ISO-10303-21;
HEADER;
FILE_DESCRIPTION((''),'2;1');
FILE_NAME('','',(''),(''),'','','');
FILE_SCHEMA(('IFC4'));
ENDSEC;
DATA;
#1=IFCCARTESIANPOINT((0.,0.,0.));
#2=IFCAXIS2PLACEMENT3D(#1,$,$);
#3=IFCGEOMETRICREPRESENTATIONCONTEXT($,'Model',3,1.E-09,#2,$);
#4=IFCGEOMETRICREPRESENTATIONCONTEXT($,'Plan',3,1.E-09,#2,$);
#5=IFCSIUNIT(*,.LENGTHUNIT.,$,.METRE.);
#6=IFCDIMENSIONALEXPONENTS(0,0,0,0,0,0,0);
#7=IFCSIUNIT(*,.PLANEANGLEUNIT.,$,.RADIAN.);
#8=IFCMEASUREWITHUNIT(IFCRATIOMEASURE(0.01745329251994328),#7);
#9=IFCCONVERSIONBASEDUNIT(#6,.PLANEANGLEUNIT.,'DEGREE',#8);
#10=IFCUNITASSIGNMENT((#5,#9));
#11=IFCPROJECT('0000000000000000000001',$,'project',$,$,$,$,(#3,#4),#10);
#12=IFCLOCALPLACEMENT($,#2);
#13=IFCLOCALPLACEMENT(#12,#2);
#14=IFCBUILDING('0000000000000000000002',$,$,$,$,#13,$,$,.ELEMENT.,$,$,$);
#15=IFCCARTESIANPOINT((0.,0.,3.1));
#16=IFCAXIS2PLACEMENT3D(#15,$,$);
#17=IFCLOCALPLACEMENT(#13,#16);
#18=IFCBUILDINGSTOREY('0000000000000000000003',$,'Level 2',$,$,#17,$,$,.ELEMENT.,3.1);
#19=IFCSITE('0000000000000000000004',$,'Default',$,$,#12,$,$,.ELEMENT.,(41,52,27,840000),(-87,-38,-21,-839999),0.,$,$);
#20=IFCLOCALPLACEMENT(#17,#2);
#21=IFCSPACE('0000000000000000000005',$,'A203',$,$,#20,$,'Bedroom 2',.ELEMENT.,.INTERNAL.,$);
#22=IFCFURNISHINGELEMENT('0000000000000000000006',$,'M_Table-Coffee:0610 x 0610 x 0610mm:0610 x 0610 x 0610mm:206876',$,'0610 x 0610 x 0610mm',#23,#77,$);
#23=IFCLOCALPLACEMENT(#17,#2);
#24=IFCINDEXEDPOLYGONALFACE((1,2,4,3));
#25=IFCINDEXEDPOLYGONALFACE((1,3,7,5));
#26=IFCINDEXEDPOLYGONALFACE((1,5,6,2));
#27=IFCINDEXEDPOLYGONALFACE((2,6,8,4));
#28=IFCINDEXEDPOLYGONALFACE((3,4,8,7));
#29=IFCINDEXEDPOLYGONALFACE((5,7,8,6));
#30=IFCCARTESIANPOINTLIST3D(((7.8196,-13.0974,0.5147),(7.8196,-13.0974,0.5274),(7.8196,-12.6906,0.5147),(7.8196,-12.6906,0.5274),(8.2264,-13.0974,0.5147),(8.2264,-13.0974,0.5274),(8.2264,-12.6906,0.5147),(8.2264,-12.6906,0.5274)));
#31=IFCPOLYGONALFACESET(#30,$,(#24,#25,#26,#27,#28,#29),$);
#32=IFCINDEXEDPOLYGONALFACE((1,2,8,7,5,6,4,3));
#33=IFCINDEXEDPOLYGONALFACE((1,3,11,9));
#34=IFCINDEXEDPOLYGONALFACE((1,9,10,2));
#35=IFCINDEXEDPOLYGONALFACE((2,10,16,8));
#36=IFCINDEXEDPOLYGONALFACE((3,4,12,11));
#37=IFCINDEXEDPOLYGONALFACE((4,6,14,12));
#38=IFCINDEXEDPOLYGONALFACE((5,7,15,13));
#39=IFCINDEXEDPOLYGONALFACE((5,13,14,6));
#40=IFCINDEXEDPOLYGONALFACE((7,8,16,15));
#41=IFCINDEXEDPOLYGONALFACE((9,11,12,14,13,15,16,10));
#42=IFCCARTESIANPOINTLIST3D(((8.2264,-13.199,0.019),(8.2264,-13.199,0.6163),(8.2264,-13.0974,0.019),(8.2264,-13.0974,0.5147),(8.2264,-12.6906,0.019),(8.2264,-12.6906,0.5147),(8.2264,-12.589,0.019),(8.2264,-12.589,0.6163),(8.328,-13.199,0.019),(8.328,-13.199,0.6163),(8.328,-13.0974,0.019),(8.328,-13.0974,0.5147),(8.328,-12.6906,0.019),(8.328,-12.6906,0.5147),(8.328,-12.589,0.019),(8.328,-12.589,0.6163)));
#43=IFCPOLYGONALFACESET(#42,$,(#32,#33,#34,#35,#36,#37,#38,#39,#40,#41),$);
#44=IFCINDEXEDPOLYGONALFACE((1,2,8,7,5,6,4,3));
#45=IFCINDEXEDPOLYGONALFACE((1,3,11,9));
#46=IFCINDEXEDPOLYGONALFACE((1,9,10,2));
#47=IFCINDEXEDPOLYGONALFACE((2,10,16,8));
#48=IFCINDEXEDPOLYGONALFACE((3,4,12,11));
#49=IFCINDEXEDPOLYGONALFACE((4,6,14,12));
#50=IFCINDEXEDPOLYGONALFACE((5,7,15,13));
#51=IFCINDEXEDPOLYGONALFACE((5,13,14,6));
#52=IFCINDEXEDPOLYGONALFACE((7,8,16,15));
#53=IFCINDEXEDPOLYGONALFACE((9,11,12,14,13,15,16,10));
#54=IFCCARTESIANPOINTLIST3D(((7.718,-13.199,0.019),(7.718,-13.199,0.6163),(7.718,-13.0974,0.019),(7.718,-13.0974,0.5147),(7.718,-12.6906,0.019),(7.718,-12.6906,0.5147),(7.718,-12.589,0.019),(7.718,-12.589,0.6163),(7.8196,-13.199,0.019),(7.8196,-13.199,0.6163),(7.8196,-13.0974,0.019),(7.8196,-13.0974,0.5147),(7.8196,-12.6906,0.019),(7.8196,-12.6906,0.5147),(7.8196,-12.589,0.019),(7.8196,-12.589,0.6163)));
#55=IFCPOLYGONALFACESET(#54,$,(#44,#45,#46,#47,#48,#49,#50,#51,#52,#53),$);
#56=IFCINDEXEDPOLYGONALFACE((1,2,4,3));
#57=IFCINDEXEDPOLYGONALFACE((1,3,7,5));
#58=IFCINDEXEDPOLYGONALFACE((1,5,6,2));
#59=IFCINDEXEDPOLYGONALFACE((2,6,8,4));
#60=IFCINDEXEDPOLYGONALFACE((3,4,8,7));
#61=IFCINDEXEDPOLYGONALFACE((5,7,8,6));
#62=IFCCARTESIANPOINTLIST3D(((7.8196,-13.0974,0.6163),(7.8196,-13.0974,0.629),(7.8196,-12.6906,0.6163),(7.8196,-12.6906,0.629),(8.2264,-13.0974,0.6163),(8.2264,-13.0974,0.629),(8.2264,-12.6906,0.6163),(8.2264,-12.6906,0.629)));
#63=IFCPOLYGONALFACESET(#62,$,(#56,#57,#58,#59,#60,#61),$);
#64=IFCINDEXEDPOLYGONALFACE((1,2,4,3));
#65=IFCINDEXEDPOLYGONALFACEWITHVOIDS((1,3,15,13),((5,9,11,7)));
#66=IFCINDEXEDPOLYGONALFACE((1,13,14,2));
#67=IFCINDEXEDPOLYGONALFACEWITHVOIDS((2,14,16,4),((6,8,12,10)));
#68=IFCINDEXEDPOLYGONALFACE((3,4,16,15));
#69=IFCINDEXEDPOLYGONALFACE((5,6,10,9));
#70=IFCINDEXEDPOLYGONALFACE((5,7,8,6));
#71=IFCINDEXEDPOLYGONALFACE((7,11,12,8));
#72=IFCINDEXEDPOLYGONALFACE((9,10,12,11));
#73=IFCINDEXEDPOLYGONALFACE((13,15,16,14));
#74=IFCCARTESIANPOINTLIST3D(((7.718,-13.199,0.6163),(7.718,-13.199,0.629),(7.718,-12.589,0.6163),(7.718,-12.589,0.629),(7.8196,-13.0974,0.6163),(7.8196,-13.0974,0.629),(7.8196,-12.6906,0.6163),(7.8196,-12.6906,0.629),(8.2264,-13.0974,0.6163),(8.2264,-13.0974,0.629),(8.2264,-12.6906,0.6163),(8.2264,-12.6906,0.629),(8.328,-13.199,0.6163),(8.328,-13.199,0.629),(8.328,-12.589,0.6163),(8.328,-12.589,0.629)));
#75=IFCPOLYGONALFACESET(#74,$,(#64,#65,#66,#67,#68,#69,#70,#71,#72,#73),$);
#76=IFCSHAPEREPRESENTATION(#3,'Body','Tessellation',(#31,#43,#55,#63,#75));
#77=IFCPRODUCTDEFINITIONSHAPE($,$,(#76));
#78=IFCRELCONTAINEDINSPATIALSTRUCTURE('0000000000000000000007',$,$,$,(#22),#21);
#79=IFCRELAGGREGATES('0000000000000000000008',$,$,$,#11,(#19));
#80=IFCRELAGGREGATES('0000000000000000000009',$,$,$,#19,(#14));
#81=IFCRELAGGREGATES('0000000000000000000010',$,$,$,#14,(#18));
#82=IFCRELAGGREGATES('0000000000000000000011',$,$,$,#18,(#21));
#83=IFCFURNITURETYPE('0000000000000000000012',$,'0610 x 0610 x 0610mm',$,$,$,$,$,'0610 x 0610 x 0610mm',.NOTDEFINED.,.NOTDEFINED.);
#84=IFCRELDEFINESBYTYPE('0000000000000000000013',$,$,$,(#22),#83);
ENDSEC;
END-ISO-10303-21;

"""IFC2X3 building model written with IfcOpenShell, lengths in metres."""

from ifc_helpers import new_model, entity, si_unit, converted_unit, frame, origin, origin_2d_with_axis, place, context, project, spatial, polyline, rectangle, outline, extrude, source, transform, mapped, type_object, type_shapes, element, save


model = new_model("IFC2X3")

# Units and contexts
model_context = context("Model", 3, precision=1e-09, world=origin())
plan_context = context("Plan", 3, precision=1e-09, world=origin())
ifc_project = project(units=[si_unit("LENGTHUNIT", "METRE"), converted_unit("PLANEANGLEUNIT", "DEGREE", entity("IfcRatioMeasure", 0.01745329251994328), si_unit("PLANEANGLEUNIT", "RADIAN"), dimensions=[0, 0, 0, 0, 0, 0, 0])], contexts=[model_context, plan_context])

# Site, building, storey
site_placement = place(None, origin())
site = spatial("IfcSite", under=ifc_project, at=site_placement, Name="Default", CompositionType="ELEMENT", RefLatitude=(41, 52, 27, 840000), RefLongitude=(-87, -38, -21, -839999), RefElevation=0.0)
building_placement = place(site_placement, origin())
building = spatial("IfcBuilding", under=site, at=building_placement, CompositionType="ELEMENT")
storey_placement = place(building_placement, frame((0.0, 0.0, 3.1)))
storey = spatial("IfcBuildingStorey", under=building, at=storey_placement, Name="Level 2", CompositionType="ELEMENT", Elevation=3.1)

# Shared definitions
space_placement = place(storey_placement, origin())
space = spatial("IfcSpace", under=storey, at=space_placement, Name="A203", LongName="Bedroom 2", CompositionType="ELEMENT", InteriorOrExteriorSpace="INTERNAL")

# Furnishing element
furniture_type = type_object("IfcFurnitureType", Name="0610 x 0610 x 0610mm", ElementType="0610 x 0610 x 0610mm", AssemblyPlace="NOTDEFINED")
shared_shape = source(origin(), model_context, "Body", "SweptSolid", [
    extrude(rectangle(XDim=0.4068, YDim=0.4068, at=origin_2d_with_axis()), frame((0.0183, 0.0952, 0.4957), z_axis=(0.0, 0.0, 1.0), x_axis=(-1.0, 0.0, 0.0)), (0.0, 0.0, 1.0), 0.0127),
    extrude(outline(polyline([(-0.2732, -0.305), (0.324, -0.305), (0.324, 0.305), (-0.2732, 0.305), (-0.2732, 0.2034), (0.2225, 0.2034), (0.2225, -0.2034), (-0.2732, -0.2034), (-0.2732, -0.305)])), frame((0.2217, 0.0952, 0.2732), z_axis=(1.0, 0.0, 0.0), x_axis=(0.0, 0.0, 1.0)), (0.0, 0.0, 1.0), 0.1016),
    extrude(outline(polyline([(-0.305, -0.3241), (0.305, -0.3241), (0.305, 0.2733), (0.2034, 0.2733), (0.2034, -0.2224), (-0.2034, -0.2224), (-0.2034, 0.2733), (-0.305, 0.2733), (-0.305, -0.3241)])), frame((-0.2867, 0.0952, 0.2733), z_axis=(1.0, 0.0, 0.0), x_axis=(0.0, -1.0, 0.0)), (0.0, 0.0, 1.0), 0.1016),
    extrude(rectangle(XDim=0.4068, YDim=0.4068, at=origin_2d_with_axis()), frame((0.0183, 0.0952, 0.5973), z_axis=(0.0, 0.0, 1.0), x_axis=(-1.0, 0.0, 0.0)), (0.0, 0.0, 1.0), 0.0127),
    extrude(outline(polyline([(-0.305, -0.305), (0.305, -0.305), (0.305, 0.305), (-0.305, 0.305), (-0.305, -0.305)]), holes=[polyline([(-0.2034, -0.2034), (-0.2034, 0.2034), (0.2034, 0.2034), (0.2034, -0.2034), (-0.2034, -0.2034)])]), frame((0.0183, 0.0952, 0.5973), z_axis=(0.0, 0.0, 1.0), x_axis=(-1.0, 0.0, 0.0)), (0.0, 0.0, 1.0), 0.0127),
])
type_shapes(furniture_type, [shared_shape])
furnishing_placement = place(space_placement, frame((8.0047, -12.9892, 0.019)))
element("IfcFurnishingElement", 1, at=furnishing_placement, inside=space, type_object=furniture_type, Name="M_Table-Coffee:0610 x 0610 x 0610mm:0610 x 0610 x 0610mm:206876", ObjectType="0610 x 0610 x 0610mm", context=model_context, shape_type="MappedRepresentation", body=[
    mapped(shared_shape, transform((0.0, 0.0, 0.0), scale=1.0)),
])

save(model, "model.ifc")
